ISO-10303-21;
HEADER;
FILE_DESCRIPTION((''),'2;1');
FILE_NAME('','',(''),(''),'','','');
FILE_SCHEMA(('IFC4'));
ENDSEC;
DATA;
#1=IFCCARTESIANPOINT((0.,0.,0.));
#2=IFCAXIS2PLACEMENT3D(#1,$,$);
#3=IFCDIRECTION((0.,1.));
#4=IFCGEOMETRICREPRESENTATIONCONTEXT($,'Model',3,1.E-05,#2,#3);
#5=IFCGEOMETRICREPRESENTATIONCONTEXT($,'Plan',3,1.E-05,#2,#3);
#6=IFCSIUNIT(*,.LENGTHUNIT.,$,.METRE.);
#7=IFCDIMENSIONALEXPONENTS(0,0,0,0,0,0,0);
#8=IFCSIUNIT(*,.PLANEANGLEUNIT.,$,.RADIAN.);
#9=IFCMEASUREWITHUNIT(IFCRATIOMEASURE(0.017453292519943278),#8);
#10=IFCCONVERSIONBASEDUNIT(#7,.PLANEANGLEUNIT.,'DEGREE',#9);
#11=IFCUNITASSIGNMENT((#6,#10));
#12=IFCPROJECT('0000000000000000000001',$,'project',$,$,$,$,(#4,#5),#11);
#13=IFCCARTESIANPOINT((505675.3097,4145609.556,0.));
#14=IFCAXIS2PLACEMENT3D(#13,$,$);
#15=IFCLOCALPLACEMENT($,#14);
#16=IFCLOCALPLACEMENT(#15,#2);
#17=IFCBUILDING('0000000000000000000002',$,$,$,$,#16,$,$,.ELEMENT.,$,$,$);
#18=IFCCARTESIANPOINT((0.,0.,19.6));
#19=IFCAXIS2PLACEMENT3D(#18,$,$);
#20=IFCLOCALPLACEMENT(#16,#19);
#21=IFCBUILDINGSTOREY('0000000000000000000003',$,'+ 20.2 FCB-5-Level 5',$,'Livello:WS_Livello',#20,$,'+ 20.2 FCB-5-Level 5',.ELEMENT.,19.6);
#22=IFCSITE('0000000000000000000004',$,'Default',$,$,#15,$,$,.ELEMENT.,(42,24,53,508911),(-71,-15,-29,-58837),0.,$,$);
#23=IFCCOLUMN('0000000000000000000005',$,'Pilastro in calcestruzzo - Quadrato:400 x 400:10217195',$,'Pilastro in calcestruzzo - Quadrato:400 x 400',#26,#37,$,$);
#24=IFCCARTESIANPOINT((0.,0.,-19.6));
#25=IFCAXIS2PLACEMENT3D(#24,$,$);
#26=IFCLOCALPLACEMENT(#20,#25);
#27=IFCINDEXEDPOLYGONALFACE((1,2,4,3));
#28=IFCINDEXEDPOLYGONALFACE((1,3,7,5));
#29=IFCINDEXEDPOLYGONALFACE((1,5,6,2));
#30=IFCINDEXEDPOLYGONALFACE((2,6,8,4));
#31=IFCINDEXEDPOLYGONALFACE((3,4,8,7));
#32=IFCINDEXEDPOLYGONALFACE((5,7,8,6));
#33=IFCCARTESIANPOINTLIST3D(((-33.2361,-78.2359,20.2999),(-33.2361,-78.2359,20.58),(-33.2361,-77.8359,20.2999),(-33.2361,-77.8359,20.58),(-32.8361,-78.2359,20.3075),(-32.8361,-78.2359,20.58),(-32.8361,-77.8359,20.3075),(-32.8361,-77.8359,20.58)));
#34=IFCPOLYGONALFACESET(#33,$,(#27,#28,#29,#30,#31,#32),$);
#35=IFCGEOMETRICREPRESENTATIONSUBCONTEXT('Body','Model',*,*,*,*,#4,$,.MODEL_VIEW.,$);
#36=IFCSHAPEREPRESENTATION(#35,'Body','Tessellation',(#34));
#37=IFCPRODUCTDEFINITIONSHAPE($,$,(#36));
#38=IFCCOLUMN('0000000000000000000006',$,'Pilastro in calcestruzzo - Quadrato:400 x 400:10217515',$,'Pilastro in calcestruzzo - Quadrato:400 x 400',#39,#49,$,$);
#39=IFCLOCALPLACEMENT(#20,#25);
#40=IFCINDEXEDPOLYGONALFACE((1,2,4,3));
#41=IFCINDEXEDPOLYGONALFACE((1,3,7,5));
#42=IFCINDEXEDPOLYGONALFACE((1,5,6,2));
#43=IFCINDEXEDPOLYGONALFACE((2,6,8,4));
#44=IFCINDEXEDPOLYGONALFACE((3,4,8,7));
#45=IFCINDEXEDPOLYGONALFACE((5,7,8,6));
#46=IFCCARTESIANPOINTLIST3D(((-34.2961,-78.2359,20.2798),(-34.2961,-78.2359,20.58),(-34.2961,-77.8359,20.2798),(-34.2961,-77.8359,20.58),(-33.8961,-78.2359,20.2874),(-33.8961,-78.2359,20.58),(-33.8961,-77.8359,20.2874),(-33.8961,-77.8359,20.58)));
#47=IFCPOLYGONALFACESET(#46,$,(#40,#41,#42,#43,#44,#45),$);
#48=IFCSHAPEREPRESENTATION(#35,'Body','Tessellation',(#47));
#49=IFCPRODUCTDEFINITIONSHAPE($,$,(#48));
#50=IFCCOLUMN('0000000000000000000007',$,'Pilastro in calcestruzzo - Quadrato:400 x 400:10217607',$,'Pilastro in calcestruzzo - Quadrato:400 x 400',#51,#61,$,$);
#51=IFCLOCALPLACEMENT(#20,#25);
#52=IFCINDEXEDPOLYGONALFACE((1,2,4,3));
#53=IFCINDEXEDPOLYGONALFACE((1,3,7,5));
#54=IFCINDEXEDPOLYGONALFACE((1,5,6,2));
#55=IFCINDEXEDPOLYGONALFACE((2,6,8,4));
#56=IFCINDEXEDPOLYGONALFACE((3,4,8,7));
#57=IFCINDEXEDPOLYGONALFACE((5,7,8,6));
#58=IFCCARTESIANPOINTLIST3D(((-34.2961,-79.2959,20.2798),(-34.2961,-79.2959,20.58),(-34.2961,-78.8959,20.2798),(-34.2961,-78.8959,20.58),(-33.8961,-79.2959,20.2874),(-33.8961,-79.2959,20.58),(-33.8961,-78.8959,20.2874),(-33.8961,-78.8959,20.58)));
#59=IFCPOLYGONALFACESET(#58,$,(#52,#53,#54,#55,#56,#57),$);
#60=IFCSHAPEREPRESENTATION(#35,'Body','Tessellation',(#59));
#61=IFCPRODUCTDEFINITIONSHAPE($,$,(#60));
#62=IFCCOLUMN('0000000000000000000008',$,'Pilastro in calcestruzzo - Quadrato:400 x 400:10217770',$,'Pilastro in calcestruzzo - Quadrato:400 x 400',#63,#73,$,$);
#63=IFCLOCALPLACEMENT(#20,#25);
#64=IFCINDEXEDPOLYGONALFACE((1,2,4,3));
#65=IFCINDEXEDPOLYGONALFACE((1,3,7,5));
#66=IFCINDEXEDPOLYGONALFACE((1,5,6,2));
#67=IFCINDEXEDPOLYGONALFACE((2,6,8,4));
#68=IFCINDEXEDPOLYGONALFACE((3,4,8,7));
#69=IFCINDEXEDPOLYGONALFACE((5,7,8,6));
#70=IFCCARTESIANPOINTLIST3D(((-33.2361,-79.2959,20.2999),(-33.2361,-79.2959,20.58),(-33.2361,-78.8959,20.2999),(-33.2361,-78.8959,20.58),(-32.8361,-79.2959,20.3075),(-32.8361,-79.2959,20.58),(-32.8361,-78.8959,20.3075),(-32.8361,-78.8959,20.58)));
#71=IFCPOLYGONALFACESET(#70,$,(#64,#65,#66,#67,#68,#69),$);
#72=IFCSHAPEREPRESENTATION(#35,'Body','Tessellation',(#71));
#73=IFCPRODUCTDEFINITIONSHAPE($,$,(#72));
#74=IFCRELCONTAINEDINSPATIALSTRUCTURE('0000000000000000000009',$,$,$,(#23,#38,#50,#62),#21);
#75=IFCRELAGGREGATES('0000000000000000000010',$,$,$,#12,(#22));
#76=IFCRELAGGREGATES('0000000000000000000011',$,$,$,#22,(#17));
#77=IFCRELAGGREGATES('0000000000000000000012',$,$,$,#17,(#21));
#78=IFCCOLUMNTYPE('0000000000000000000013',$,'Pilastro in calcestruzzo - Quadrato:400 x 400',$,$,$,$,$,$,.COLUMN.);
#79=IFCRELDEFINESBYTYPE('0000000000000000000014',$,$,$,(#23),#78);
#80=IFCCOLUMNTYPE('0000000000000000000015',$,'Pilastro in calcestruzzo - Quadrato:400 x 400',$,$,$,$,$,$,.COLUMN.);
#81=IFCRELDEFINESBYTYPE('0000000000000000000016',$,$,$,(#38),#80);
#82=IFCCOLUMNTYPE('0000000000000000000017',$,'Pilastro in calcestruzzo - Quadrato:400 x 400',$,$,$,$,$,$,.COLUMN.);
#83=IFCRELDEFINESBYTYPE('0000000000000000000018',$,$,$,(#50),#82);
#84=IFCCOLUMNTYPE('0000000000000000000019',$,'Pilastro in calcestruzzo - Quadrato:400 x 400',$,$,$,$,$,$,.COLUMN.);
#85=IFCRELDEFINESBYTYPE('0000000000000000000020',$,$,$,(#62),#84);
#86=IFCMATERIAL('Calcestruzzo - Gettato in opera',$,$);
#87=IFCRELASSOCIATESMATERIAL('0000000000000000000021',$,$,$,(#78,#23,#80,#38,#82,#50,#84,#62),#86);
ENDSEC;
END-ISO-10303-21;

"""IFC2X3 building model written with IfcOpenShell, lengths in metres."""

from ifc_helpers import new_model, entity, si_unit, converted_unit, direction, frame, frame_2d, origin, place, context, subcontext, project, spatial, rectangle, extrude, clip, halfspace, source, transform, mapped, material, type_object, type_shapes, element, save


model = new_model("IFC2X3")

# Units and contexts
model_context = context("Model", 3, precision=1e-05, world=origin(), true_north=direction((0.0, 1.0)))
plan_context = context("Plan", 3, precision=1e-05, world=origin(), true_north=direction((0.0, 1.0)))
body_context = subcontext(model_context, "Body", "Model", "MODEL_VIEW")
ifc_project = project(units=[si_unit("LENGTHUNIT", "METRE"), converted_unit("PLANEANGLEUNIT", "DEGREE", entity("IfcRatioMeasure", 0.017453292519943278), si_unit("PLANEANGLEUNIT", "RADIAN"), dimensions=[0, 0, 0, 0, 0, 0, 0])], contexts=[model_context, plan_context])

# Site, building, storey
site_placement = place(None, frame((505675.3097, 4145609.556, 0.0)))
site = spatial("IfcSite", under=ifc_project, at=site_placement, Name="Default", CompositionType="ELEMENT", RefLatitude=(42, 24, 53, 508911), RefLongitude=(-71, -15, -29, -58837), RefElevation=0.0)
building_placement = place(site_placement, origin())
building = spatial("IfcBuilding", under=site, at=building_placement, CompositionType="ELEMENT")
storey_placement = place(building_placement, frame((0.0, 0.0, 19.6)))
storey = spatial("IfcBuildingStorey", under=building, at=storey_placement, Name="+ 20.2 FCB-5-Level 5", ObjectType="Livello:WS_Livello", LongName="+ 20.2 FCB-5-Level 5", CompositionType="ELEMENT", Elevation=19.6)

# Columns
ifc_material_1 = material(Name="Calcestruzzo - Gettato in opera")
column_type_1 = type_object("IfcColumnType", Name="Pilastro in calcestruzzo - Quadrato:400 x 400", PredefinedType="COLUMN", material=ifc_material_1)
shared_shape_1 = source(origin(), body_context, "Body", "SweptSolid", [
    clip(extrude(rectangle(XDim=0.4, YDim=0.4, at=frame_2d((0.0, 0.0), x_axis=(1.0, 0.0))), frame((-33.0361, -78.0359, 20.2999), z_axis=(0.0, 0.0, 1.0), x_axis=(0.0, -1.0, 0.0)), (0.0, 0.0, 1.0), 0.2801), halfspace(frame((-38.4861, -87.2979, 20.2), z_axis=(0.019032, 0.0, -0.999819), x_axis=(-0.999819, 0.0, -0.019032)), False)),
])
type_shapes(column_type_1, [shared_shape_1])
column_1_placement = place(storey_placement, frame((0.0, 0.0, -19.6)))
element("IfcColumn", 1, at=column_1_placement, inside=storey, type_object=column_type_1, material=ifc_material_1, Name="Pilastro in calcestruzzo - Quadrato:400 x 400:10217195", ObjectType="Pilastro in calcestruzzo - Quadrato:400 x 400", context=body_context, shape_type="MappedRepresentation", body=[
    mapped(shared_shape_1, transform((0.0, 0.0, 0.0), scale=1.0)),
])
column_type_2 = type_object("IfcColumnType", Name="Pilastro in calcestruzzo - Quadrato:400 x 400", PredefinedType="COLUMN", material=ifc_material_1)
shared_shape_2 = source(origin(), body_context, "Body", "SweptSolid", [
    clip(extrude(rectangle(XDim=0.4, YDim=0.4, at=frame_2d((0.0, 0.0), x_axis=(1.0, 0.0))), frame((-34.0961, -78.0359, 20.2798), z_axis=(0.0, 0.0, 1.0), x_axis=(0.0, -1.0, 0.0)), (0.0, 0.0, 1.0), 0.3002), halfspace(frame((-38.4861, -87.2979, 20.2), z_axis=(0.019032, 0.0, -0.999819), x_axis=(-0.999819, 0.0, -0.019032)), False)),
])
type_shapes(column_type_2, [shared_shape_2])
column_2_placement = place(storey_placement, frame((0.0, 0.0, -19.6)))
element("IfcColumn", 2, at=column_2_placement, inside=storey, type_object=column_type_2, material=ifc_material_1, Name="Pilastro in calcestruzzo - Quadrato:400 x 400:10217515", ObjectType="Pilastro in calcestruzzo - Quadrato:400 x 400", context=body_context, shape_type="MappedRepresentation", body=[
    mapped(shared_shape_2, transform((0.0, 0.0, 0.0), scale=1.0)),
])
column_type_3 = type_object("IfcColumnType", Name="Pilastro in calcestruzzo - Quadrato:400 x 400", PredefinedType="COLUMN", material=ifc_material_1)
shared_shape_3 = source(origin(), body_context, "Body", "SweptSolid", [
    clip(extrude(rectangle(XDim=0.4, YDim=0.4, at=frame_2d((0.0, 0.0), x_axis=(1.0, 0.0))), frame((-34.0961, -79.0959, 20.2798), z_axis=(0.0, 0.0, 1.0), x_axis=(0.0, -1.0, 0.0)), (0.0, 0.0, 1.0), 0.3002), halfspace(frame((-38.4861, -87.2979, 20.2), z_axis=(0.019032, 0.0, -0.999819), x_axis=(-0.999819, 0.0, -0.019032)), False)),
])
type_shapes(column_type_3, [shared_shape_3])
column_3_placement = place(storey_placement, frame((0.0, 0.0, -19.6)))
element("IfcColumn", 3, at=column_3_placement, inside=storey, type_object=column_type_3, material=ifc_material_1, Name="Pilastro in calcestruzzo - Quadrato:400 x 400:10217607", ObjectType="Pilastro in calcestruzzo - Quadrato:400 x 400", context=body_context, shape_type="MappedRepresentation", body=[
    mapped(shared_shape_3, transform((0.0, 0.0, 0.0), scale=1.0)),
])
column_type_4 = type_object("IfcColumnType", Name="Pilastro in calcestruzzo - Quadrato:400 x 400", PredefinedType="COLUMN", material=ifc_material_1)
shared_shape_4 = source(origin(), body_context, "Body", "SweptSolid", [
    clip(extrude(rectangle(XDim=0.4, YDim=0.4, at=frame_2d((0.0, 0.0), x_axis=(1.0, 0.0))), frame((-33.0361, -79.0959, 20.2999), z_axis=(0.0, 0.0, 1.0), x_axis=(0.0, -1.0, 0.0)), (0.0, 0.0, 1.0), 0.2801), halfspace(frame((-38.4861, -87.2979, 20.2), z_axis=(0.019032, 0.0, -0.999819), x_axis=(-0.999819, 0.0, -0.019032)), False)),
])
type_shapes(column_type_4, [shared_shape_4])
column_4_placement = place(storey_placement, frame((0.0, 0.0, -19.6)))
element("IfcColumn", 4, at=column_4_placement, inside=storey, type_object=column_type_4, material=ifc_material_1, Name="Pilastro in calcestruzzo - Quadrato:400 x 400:10217770", ObjectType="Pilastro in calcestruzzo - Quadrato:400 x 400", context=body_context, shape_type="MappedRepresentation", body=[
    mapped(shared_shape_4, transform((0.0, 0.0, 0.0), scale=1.0)),
])

save(model, "model.ifc")
